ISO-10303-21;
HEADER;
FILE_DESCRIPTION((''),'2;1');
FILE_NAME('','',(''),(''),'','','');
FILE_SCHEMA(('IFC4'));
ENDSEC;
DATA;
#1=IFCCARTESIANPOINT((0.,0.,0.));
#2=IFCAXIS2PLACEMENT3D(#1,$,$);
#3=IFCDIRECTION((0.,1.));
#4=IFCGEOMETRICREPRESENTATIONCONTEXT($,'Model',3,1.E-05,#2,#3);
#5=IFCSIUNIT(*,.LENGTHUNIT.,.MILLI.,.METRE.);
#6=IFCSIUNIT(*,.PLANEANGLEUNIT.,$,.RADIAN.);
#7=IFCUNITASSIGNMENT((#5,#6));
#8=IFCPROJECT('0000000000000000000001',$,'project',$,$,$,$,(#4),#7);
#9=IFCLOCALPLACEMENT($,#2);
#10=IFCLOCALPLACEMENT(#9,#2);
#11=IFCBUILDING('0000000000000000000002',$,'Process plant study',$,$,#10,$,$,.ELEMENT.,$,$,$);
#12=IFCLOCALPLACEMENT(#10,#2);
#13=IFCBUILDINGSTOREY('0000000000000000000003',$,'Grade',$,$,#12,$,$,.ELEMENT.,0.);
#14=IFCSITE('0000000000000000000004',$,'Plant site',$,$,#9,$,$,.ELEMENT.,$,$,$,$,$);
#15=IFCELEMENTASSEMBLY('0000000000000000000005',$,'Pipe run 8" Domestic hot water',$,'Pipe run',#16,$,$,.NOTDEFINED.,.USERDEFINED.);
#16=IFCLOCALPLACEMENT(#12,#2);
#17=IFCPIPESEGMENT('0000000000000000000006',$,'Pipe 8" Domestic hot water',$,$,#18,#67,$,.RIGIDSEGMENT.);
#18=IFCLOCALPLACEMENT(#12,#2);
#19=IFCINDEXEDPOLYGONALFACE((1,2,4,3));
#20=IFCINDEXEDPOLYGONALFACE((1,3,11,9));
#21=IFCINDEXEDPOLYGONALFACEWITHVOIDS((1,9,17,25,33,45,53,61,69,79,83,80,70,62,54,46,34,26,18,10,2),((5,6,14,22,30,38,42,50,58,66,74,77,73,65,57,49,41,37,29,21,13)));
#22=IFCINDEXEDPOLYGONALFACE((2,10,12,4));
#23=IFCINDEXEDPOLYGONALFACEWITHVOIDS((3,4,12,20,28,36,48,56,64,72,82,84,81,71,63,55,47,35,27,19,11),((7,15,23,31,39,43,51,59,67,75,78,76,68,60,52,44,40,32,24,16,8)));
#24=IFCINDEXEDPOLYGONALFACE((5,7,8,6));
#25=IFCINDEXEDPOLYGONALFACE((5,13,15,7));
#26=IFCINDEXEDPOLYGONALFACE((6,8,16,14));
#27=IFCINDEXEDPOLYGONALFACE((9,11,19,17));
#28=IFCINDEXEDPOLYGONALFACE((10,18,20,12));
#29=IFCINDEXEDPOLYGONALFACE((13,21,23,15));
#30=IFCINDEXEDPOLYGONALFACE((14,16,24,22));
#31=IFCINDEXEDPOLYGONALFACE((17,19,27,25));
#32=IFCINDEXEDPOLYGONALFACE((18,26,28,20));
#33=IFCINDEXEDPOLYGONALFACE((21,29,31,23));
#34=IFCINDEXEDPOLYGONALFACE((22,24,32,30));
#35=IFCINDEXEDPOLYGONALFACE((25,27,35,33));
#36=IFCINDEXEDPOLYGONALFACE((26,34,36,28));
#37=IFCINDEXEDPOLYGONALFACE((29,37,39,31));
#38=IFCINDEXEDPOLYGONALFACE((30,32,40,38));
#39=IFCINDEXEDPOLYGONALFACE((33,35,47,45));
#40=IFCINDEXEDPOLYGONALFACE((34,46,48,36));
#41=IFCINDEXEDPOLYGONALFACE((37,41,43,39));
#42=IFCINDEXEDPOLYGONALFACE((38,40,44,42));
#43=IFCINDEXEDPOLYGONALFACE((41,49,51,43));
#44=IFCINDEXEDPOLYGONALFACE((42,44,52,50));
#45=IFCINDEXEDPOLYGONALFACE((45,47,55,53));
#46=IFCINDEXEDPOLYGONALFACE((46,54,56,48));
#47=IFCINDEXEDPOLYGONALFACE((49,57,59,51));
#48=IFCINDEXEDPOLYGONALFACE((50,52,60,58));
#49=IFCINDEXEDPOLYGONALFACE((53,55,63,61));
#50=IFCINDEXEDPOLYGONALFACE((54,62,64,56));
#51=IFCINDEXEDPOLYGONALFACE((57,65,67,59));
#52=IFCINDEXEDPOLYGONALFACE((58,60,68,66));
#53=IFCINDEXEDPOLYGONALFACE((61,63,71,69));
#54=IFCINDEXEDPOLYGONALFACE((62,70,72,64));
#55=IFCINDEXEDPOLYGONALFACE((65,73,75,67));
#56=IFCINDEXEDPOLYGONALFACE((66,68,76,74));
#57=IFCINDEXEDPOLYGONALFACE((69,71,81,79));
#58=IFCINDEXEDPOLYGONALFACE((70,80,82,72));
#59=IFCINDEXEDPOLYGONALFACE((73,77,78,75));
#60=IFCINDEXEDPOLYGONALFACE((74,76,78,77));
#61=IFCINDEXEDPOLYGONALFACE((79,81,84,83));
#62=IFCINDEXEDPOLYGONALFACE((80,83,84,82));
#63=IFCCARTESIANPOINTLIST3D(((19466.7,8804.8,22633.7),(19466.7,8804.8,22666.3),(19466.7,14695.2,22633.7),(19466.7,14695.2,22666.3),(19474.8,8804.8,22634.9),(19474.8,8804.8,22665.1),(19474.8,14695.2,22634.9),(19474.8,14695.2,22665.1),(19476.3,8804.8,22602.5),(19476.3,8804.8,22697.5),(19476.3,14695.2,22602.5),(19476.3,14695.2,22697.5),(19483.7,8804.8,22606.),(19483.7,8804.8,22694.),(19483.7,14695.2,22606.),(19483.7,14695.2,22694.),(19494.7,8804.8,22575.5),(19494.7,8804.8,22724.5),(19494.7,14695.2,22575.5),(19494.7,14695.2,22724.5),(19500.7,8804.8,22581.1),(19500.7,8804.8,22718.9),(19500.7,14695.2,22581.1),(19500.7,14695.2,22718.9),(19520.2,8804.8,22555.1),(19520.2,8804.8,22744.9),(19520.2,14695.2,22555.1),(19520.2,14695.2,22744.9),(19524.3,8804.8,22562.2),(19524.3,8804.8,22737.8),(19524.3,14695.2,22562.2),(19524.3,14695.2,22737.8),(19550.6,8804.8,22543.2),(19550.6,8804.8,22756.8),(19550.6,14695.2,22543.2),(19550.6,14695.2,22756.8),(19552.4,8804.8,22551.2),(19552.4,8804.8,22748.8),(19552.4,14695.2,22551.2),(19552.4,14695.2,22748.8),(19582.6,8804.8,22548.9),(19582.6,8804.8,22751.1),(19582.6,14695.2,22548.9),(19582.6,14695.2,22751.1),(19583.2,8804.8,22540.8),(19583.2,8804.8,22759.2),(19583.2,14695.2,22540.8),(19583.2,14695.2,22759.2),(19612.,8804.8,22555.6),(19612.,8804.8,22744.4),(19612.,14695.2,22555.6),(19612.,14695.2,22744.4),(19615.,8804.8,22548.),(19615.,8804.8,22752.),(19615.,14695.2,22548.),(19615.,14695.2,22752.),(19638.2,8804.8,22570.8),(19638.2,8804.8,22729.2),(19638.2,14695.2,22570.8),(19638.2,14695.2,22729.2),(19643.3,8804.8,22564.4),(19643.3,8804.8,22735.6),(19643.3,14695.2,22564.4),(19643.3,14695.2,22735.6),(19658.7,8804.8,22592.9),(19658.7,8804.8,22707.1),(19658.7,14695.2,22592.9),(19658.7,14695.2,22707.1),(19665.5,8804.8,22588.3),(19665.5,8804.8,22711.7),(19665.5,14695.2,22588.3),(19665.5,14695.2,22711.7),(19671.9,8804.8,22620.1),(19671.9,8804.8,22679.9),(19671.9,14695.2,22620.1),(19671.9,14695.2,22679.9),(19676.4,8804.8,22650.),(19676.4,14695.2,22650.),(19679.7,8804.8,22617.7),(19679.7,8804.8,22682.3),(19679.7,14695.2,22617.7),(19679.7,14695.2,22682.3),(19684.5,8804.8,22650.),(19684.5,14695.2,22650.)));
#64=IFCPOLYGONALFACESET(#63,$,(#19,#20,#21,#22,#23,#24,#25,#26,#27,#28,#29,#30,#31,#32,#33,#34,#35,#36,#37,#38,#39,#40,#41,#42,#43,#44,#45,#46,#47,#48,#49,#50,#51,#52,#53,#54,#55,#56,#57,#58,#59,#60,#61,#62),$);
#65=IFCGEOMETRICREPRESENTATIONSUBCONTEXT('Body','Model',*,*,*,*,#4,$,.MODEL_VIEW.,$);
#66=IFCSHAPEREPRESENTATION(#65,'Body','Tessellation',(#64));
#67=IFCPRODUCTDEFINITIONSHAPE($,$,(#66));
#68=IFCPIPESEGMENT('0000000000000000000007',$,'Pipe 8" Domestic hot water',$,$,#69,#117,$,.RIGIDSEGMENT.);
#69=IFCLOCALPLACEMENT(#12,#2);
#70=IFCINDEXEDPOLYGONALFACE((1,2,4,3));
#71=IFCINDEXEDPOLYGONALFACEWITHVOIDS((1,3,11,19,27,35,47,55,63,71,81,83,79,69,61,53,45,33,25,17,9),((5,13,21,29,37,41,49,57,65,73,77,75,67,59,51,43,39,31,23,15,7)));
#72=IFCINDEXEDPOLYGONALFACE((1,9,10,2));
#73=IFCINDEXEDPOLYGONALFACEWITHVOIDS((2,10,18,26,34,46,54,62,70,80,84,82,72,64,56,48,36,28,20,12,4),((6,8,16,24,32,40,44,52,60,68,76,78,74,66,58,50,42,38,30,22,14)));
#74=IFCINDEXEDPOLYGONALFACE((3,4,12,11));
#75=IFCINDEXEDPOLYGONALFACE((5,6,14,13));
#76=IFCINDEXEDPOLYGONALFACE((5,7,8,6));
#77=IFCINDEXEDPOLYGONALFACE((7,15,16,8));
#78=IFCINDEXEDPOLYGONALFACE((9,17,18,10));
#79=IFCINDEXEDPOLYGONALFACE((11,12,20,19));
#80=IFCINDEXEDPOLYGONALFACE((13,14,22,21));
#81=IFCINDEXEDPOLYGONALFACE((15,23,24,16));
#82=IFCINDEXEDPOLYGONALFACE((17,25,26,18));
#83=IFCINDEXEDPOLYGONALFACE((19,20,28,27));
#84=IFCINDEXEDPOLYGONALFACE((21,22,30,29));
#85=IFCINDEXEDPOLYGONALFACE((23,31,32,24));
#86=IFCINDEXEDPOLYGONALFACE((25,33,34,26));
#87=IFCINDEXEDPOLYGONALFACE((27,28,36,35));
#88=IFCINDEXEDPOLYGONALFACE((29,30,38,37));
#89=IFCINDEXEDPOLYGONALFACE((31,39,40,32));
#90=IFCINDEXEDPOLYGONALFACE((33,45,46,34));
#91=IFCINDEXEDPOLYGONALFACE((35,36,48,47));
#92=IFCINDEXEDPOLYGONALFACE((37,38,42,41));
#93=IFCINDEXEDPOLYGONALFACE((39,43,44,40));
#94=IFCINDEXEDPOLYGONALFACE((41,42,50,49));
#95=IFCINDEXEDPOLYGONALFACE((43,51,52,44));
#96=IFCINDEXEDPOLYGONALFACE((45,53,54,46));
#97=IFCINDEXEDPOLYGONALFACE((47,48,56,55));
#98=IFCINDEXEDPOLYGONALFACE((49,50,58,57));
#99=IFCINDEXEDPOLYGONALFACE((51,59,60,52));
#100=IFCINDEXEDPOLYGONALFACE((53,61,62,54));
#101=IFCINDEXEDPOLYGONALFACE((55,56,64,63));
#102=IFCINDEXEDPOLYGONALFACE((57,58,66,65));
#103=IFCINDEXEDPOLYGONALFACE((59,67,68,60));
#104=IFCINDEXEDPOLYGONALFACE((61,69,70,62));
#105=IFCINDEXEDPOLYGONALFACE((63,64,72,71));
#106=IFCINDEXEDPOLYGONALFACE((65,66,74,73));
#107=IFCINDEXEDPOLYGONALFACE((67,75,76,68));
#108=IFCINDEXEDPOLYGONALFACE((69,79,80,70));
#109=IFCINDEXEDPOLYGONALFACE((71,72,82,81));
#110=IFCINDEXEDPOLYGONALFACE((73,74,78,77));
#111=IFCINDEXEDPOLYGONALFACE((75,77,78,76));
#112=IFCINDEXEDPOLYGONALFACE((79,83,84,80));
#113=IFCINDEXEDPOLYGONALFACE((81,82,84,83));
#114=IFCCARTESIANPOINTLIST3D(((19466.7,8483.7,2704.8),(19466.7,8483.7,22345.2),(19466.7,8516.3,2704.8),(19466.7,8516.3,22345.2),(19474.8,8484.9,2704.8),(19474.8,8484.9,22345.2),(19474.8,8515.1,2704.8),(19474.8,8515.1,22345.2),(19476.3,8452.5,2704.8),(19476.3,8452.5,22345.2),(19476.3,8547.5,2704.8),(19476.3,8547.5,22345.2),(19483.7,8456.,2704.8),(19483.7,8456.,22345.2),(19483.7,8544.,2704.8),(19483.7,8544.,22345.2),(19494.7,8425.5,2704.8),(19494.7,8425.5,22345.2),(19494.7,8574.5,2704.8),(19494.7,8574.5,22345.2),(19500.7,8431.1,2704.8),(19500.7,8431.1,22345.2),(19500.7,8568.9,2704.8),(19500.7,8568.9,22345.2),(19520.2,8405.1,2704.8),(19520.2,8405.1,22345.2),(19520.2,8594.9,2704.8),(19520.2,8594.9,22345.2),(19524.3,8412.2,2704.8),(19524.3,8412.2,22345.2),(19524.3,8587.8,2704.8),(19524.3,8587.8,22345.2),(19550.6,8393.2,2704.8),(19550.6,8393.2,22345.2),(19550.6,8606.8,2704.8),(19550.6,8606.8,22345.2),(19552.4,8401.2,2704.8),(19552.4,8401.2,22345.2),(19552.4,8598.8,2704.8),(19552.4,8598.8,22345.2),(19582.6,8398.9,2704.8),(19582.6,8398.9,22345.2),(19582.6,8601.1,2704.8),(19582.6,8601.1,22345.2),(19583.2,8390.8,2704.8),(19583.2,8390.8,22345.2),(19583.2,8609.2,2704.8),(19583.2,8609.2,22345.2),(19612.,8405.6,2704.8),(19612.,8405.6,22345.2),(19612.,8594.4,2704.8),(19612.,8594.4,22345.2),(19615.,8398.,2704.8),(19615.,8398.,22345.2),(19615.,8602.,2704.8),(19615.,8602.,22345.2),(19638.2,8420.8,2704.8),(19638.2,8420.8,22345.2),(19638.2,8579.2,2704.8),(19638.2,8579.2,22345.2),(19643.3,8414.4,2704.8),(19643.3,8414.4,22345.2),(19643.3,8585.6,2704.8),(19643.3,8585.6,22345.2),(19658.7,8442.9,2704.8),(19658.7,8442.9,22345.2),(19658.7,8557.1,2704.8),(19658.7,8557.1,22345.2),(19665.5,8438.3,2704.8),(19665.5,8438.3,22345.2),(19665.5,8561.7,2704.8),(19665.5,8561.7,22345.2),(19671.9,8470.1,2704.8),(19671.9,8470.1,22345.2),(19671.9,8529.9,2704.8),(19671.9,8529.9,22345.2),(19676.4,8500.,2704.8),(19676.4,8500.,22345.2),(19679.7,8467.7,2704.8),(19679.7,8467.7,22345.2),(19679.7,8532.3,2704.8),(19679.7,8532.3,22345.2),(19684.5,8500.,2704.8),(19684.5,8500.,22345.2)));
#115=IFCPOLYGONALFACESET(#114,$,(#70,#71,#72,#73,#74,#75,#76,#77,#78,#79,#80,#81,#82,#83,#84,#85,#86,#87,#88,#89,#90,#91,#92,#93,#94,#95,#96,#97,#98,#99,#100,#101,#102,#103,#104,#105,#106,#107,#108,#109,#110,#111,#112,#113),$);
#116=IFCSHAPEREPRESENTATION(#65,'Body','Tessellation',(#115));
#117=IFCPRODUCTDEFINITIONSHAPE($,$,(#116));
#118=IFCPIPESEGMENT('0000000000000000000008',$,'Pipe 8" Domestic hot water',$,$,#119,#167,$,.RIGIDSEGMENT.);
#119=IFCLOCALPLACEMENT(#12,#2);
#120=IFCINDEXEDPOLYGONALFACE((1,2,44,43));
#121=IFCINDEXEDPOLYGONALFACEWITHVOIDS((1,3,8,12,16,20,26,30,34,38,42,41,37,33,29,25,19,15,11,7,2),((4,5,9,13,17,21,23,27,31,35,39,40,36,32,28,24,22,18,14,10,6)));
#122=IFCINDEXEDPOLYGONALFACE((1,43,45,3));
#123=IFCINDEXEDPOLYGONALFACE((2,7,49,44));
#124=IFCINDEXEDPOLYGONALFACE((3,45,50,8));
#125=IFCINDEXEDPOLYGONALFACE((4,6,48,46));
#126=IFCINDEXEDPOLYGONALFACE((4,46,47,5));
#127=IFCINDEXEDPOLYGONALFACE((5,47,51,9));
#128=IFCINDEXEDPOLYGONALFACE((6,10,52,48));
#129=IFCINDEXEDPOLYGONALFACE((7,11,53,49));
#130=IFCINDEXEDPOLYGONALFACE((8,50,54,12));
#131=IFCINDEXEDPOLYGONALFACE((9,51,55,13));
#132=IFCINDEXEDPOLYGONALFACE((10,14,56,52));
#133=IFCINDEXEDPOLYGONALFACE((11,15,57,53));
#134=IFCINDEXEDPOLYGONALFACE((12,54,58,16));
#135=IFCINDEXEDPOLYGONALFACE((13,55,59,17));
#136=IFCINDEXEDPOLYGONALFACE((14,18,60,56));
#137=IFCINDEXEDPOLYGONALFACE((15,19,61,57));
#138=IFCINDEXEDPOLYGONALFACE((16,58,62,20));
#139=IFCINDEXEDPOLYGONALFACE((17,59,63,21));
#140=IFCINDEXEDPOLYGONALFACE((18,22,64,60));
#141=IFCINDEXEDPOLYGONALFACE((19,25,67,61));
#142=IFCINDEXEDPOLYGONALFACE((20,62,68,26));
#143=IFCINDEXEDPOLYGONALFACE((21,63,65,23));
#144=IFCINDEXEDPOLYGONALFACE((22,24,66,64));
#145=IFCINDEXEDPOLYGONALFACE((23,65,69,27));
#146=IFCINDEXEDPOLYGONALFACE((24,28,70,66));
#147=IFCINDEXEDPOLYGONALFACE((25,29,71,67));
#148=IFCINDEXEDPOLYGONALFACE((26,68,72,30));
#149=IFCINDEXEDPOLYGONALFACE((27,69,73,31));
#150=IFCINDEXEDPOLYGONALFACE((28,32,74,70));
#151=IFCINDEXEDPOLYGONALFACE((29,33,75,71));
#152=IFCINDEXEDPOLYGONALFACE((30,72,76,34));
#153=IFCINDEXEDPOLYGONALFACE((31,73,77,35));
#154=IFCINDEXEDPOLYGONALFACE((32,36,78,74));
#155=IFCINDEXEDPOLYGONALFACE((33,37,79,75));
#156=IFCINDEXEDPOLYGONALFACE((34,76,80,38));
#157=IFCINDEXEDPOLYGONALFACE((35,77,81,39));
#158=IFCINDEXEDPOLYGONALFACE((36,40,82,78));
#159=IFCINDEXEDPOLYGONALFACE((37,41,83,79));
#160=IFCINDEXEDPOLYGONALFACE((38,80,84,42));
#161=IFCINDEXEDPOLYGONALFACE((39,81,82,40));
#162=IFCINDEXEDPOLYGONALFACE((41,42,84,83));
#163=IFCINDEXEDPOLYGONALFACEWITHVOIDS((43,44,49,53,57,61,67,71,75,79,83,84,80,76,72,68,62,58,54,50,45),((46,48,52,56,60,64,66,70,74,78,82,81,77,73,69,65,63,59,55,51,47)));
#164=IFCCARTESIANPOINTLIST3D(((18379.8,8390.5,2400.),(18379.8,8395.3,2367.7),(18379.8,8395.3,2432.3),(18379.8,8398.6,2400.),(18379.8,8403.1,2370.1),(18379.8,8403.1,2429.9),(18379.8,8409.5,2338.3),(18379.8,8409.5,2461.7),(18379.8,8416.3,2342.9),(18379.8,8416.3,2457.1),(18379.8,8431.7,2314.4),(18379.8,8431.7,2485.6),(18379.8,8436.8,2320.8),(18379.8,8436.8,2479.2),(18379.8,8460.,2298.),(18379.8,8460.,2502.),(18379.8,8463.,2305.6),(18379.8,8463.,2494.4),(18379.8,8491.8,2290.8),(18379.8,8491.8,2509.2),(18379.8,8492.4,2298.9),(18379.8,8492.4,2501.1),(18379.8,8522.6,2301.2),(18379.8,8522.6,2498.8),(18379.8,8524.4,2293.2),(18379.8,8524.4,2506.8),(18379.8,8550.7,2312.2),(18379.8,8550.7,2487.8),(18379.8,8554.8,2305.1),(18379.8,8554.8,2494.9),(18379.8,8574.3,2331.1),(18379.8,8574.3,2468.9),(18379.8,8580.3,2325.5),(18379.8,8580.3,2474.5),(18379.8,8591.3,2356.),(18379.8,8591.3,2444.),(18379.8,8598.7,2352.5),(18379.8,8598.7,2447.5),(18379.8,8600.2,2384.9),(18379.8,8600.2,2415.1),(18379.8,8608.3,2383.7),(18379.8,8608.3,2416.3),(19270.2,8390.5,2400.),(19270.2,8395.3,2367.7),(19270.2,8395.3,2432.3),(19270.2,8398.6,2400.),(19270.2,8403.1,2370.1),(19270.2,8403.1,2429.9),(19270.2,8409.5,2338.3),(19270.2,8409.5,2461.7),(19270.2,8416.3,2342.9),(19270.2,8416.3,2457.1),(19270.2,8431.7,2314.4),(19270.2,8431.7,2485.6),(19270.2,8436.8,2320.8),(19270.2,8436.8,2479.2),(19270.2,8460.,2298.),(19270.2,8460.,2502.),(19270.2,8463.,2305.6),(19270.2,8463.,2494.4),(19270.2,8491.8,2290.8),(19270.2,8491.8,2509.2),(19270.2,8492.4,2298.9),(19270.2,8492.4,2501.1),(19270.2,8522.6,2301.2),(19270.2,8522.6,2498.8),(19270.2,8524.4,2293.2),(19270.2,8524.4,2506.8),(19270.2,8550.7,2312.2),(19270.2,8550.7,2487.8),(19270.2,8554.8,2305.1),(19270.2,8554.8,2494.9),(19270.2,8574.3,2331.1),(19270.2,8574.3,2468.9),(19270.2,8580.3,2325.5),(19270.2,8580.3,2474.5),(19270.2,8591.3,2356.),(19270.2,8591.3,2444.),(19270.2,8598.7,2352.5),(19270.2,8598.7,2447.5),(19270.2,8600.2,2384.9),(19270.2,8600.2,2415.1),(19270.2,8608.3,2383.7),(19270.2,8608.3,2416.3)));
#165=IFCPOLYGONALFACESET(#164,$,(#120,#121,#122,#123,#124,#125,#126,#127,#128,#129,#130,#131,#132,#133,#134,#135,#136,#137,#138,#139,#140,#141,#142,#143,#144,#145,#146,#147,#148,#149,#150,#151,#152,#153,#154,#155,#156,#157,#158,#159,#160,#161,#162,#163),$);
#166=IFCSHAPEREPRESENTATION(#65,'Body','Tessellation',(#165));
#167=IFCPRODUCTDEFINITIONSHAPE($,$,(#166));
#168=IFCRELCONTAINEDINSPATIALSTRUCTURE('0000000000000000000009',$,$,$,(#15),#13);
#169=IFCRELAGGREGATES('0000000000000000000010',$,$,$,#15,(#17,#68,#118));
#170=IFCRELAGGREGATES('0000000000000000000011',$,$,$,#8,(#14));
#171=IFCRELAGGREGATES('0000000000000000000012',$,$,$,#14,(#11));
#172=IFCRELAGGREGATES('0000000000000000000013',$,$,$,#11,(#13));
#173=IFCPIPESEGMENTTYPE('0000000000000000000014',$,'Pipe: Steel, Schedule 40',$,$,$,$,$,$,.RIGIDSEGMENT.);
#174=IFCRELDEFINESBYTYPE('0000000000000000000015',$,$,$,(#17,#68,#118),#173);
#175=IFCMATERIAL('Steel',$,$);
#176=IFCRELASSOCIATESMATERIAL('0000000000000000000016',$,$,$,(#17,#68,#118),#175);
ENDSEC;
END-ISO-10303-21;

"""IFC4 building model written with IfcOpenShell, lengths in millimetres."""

from ifc_helpers import new_model, si_unit, direction, frame, origin, origin_with_axes, origin_2d, place, context, subcontext, project, spatial, hollow_circle, extrude, material, type_object, element, aggregate, save


model = new_model("IFC4")

# Units and contexts
model_context = context("Model", 3, precision=1e-05, world=origin(), true_north=direction((0.0, 1.0)))
body_context = subcontext(model_context, "Body", "Model", "MODEL_VIEW")
ifc_project = project(units=[si_unit("LENGTHUNIT", "METRE", prefix="MILLI"), si_unit("PLANEANGLEUNIT", "RADIAN")], contexts=[model_context])

# Site, building, storey
site_placement = place(None, origin())
site = spatial("IfcSite", under=ifc_project, at=site_placement, Name="Plant site", CompositionType="ELEMENT")
building_placement = place(site_placement, origin())
building = spatial("IfcBuilding", under=site, at=building_placement, Name="Process plant study", CompositionType="ELEMENT")
storey_placement = place(building_placement, origin())
storey = spatial("IfcBuildingStorey", under=building, at=storey_placement, Name="Grade", CompositionType="ELEMENT", Elevation=0.0)

# Element assembly, pipe segments
assembly_1_placement = place(storey_placement, origin_with_axes())
assembly_1 = element("IfcElementAssembly", 1, at=assembly_1_placement, inside=storey, Name="Pipe run 8\" Domestic hot water", ObjectType="Pipe run", AssemblyPlace="NOTDEFINED", PredefinedType="USERDEFINED")
ifc_material = material(Name="Steel")
pipe_segment_type = type_object("IfcPipeSegmentType", Name="Pipe: Steel, Schedule 40", PredefinedType="RIGIDSEGMENT")
pipe_segment_1_placement = place(storey_placement, origin_with_axes())
pipe_segment_1 = element("IfcPipeSegment", 2, at=pipe_segment_1_placement, type_object=pipe_segment_type, material=ifc_material, Name="Pipe 8\" Domestic hot water", PredefinedType="RIGIDSEGMENT", context=body_context, shape_type="SweptSolid", body=[
    extrude(hollow_circle(Radius=109.5, WallThickness=8.2, at=origin_2d()), frame((19575.0, 14695.2, 22650.0), z_axis=(0.0, -1.0, 0.0), x_axis=(1.0, 0.0, 0.0)), (0.0, 0.0, 1.0), 5890.4),
])
pipe_segment_2_placement = place(storey_placement, origin_with_axes())
pipe_segment_2 = element("IfcPipeSegment", 3, at=pipe_segment_2_placement, type_object=pipe_segment_type, material=ifc_material, Name="Pipe 8\" Domestic hot water", PredefinedType="RIGIDSEGMENT", context=body_context, shape_type="SweptSolid", body=[
    extrude(hollow_circle(Radius=109.5, WallThickness=8.2, at=origin_2d()), frame((19575.0, 8500.0, 22345.2), z_axis=(0.0, 0.0, -1.0), x_axis=(1.0, 0.0, 0.0)), (0.0, 0.0, 1.0), 19640.4),
])
pipe_segment_3_placement = place(storey_placement, origin_with_axes())
pipe_segment_3 = element("IfcPipeSegment", 4, at=pipe_segment_3_placement, type_object=pipe_segment_type, material=ifc_material, Name="Pipe 8\" Domestic hot water", PredefinedType="RIGIDSEGMENT", context=body_context, shape_type="SweptSolid", body=[
    extrude(hollow_circle(Radius=109.5, WallThickness=8.2, at=origin_2d()), frame((19270.2, 8500.0, 2400.0), z_axis=(-1.0, 0.0, 0.0), x_axis=(0.0, -1.0, 0.0)), (0.0, 0.0, 1.0), 890.4),
])

aggregate(assembly_1, [pipe_segment_1, pipe_segment_2, pipe_segment_3])

save(model, "model.ifc")
